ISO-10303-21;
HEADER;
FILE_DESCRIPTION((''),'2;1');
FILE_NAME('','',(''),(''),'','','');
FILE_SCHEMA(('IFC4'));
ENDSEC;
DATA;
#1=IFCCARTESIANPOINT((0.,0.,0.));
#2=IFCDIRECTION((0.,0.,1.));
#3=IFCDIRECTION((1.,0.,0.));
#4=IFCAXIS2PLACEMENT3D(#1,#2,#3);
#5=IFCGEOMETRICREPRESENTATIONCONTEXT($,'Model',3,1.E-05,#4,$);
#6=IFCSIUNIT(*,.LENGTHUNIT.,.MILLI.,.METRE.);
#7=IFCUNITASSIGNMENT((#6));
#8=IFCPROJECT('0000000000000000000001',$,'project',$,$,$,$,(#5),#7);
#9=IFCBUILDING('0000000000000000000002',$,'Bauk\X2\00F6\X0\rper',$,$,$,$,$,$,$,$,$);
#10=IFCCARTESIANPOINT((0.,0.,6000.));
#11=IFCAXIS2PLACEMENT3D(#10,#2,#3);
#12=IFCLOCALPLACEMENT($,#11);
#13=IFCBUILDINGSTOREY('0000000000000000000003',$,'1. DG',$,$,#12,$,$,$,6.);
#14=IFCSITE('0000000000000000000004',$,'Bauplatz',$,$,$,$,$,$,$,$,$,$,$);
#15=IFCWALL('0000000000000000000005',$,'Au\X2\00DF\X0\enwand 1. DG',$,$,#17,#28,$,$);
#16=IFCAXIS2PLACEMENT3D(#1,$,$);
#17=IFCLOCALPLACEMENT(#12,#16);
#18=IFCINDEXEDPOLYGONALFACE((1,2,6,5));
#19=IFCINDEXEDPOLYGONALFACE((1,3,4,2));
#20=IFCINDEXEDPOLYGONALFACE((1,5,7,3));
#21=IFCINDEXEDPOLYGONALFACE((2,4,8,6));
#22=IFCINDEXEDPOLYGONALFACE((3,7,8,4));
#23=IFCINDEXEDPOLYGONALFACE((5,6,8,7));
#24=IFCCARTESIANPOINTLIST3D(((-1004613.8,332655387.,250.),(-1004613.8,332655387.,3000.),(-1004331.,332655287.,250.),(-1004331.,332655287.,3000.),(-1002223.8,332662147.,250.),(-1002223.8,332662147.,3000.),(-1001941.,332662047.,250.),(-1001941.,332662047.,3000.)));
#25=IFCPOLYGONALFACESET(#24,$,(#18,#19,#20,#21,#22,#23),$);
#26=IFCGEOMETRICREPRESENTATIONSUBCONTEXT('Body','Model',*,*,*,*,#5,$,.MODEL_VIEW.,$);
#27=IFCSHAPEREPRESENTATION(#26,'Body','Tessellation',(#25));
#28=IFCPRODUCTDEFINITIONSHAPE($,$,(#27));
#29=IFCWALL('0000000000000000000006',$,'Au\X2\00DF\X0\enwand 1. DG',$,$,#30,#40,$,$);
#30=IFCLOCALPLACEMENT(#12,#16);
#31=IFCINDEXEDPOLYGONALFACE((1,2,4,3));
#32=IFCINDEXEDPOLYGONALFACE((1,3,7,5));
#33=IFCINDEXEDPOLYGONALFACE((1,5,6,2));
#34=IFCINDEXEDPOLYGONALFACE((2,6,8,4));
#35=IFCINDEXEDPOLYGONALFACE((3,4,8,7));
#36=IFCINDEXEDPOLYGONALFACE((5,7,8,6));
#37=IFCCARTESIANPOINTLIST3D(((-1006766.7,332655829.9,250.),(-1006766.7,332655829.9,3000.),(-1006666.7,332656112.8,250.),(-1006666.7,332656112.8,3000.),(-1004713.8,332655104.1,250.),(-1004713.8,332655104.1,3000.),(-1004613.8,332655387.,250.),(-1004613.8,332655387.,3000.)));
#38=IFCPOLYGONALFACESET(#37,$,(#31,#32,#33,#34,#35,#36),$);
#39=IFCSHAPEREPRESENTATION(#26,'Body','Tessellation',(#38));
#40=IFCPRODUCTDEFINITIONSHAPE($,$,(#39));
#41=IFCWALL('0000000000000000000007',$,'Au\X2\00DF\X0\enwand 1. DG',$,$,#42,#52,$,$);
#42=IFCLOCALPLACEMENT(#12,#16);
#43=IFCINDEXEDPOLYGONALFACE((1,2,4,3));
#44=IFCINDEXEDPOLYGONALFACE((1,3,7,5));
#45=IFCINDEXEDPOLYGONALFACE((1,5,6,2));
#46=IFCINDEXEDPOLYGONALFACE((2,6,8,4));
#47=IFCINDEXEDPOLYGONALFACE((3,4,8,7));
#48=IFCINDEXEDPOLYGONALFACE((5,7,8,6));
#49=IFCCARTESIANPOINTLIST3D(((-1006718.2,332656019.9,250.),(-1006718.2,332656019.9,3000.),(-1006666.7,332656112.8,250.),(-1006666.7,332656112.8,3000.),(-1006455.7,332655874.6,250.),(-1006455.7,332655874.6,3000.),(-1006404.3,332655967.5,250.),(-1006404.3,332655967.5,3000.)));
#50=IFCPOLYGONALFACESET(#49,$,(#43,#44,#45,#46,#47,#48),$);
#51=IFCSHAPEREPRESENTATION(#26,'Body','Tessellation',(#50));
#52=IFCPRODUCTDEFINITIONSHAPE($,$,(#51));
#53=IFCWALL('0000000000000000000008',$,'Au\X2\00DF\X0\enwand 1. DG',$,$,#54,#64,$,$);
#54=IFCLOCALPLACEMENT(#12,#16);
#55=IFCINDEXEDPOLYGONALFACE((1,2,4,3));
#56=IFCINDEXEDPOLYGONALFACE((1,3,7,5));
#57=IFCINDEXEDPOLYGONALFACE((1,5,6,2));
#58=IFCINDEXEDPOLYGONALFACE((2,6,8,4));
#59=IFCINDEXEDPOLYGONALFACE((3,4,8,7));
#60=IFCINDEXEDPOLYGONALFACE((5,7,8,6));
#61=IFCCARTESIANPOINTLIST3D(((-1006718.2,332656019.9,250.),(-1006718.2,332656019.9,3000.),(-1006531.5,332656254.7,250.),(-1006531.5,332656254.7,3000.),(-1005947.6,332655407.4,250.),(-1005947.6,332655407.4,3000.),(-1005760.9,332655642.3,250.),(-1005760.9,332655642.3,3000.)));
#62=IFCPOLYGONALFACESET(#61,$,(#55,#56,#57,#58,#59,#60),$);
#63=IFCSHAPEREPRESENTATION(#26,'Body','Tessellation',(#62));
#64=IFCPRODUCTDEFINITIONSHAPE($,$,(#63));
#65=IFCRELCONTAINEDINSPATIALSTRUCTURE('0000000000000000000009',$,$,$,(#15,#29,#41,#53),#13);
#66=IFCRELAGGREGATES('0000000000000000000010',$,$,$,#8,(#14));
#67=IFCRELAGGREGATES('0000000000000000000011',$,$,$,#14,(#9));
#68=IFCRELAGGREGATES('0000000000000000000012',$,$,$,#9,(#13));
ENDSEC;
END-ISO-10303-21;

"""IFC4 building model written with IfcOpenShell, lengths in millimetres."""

from ifc_helpers import new_model, si_unit, frame, origin_with_axes, place, context, subcontext, project, spatial, indexed_curve, outline, extrude, element, save


model = new_model("IFC4")

# Units and contexts
model_context = context("Model", 3, precision=1e-05, world=origin_with_axes())
body_context = subcontext(model_context, "Body", "Model", "MODEL_VIEW")
ifc_project = project(units=[si_unit("LENGTHUNIT", "METRE", prefix="MILLI")], contexts=[model_context])

# Site, building, storey
site = spatial("IfcSite", under=ifc_project, Name="Bauplatz")
building = spatial("IfcBuilding", under=site, Name="Baukörper")
storey_placement = place(None, frame((0.0, 0.0, 6000.0), z_axis=(0.0, 0.0, 1.0), x_axis=(1.0, 0.0, 0.0)))
storey = spatial("IfcBuildingStorey", under=building, at=storey_placement, Name="1. DG", Elevation=6.0)

# Walls
wall_1_placement = place(storey_placement, frame((-1002223.8, 332662147.0, 250.0), z_axis=(0.0, 0.0, 1.0), x_axis=(-0.333331, -0.94281, 0.0)))
element("IfcWall", 1, at=wall_1_placement, inside=storey, Name="Außenwand 1. DG", context=body_context, shape_type="SweptSolid", body=[
    extrude(outline(indexed_curve([(0.0, 0.0), (0.0, 300.0), (7170.1, 300.0), (7170.1, 0.0), (0.0, 0.0)], self_intersect=False)), origin_with_axes(), (0.0, 0.0, 1.0), 2750.0),
])
wall_2_placement = place(storey_placement, frame((-1004613.8, 332655387.0, 250.0), z_axis=(0.0, 0.0, 1.0), x_axis=(-0.94281, 0.333331, 0.0)))
element("IfcWall", 2, at=wall_2_placement, inside=storey, Name="Außenwand 1. DG", context=body_context, shape_type="SweptSolid", body=[
    extrude(outline(indexed_curve([(0.0, 0.0), (0.0, 300.0), (2177.4, 300.0), (2177.4, 0.0), (0.0, 0.0)], self_intersect=False)), origin_with_axes(), (0.0, 0.0, 1.0), 2750.0),
])
wall_3_placement = place(storey_placement, frame((-1006666.7, 332656112.8, 250.0), z_axis=(0.0, 0.0, 1.0), x_axis=(-0.4844, -0.874847, 0.0)))
element("IfcWall", 3, at=wall_3_placement, inside=storey, Name="Außenwand 1. DG", context=body_context, shape_type="SweptSolid", body=[
    extrude(outline(indexed_curve([(0.0, 0.0), (0.0, 300.0), (106.2, 300.0), (106.2, 0.0), (0.0, 0.0)], self_intersect=False)), origin_with_axes(), (0.0, 0.0, 1.0), 2750.0),
])
wall_4_placement = place(storey_placement, frame((-1006718.2, 332656019.9, 250.0), z_axis=(0.0, 0.0, 1.0), x_axis=(0.782875, -0.622179, 0.0)))
element("IfcWall", 4, at=wall_4_placement, inside=storey, Name="Außenwand 1. DG", context=body_context, shape_type="SweptSolid", body=[
    extrude(outline(indexed_curve([(0.0, 0.0), (0.0, 300.0), (984.4, 300.0), (984.4, 0.0), (0.0, 0.0)], self_intersect=False)), origin_with_axes(), (0.0, 0.0, 1.0), 2750.0),
])

save(model, "model.ifc")
